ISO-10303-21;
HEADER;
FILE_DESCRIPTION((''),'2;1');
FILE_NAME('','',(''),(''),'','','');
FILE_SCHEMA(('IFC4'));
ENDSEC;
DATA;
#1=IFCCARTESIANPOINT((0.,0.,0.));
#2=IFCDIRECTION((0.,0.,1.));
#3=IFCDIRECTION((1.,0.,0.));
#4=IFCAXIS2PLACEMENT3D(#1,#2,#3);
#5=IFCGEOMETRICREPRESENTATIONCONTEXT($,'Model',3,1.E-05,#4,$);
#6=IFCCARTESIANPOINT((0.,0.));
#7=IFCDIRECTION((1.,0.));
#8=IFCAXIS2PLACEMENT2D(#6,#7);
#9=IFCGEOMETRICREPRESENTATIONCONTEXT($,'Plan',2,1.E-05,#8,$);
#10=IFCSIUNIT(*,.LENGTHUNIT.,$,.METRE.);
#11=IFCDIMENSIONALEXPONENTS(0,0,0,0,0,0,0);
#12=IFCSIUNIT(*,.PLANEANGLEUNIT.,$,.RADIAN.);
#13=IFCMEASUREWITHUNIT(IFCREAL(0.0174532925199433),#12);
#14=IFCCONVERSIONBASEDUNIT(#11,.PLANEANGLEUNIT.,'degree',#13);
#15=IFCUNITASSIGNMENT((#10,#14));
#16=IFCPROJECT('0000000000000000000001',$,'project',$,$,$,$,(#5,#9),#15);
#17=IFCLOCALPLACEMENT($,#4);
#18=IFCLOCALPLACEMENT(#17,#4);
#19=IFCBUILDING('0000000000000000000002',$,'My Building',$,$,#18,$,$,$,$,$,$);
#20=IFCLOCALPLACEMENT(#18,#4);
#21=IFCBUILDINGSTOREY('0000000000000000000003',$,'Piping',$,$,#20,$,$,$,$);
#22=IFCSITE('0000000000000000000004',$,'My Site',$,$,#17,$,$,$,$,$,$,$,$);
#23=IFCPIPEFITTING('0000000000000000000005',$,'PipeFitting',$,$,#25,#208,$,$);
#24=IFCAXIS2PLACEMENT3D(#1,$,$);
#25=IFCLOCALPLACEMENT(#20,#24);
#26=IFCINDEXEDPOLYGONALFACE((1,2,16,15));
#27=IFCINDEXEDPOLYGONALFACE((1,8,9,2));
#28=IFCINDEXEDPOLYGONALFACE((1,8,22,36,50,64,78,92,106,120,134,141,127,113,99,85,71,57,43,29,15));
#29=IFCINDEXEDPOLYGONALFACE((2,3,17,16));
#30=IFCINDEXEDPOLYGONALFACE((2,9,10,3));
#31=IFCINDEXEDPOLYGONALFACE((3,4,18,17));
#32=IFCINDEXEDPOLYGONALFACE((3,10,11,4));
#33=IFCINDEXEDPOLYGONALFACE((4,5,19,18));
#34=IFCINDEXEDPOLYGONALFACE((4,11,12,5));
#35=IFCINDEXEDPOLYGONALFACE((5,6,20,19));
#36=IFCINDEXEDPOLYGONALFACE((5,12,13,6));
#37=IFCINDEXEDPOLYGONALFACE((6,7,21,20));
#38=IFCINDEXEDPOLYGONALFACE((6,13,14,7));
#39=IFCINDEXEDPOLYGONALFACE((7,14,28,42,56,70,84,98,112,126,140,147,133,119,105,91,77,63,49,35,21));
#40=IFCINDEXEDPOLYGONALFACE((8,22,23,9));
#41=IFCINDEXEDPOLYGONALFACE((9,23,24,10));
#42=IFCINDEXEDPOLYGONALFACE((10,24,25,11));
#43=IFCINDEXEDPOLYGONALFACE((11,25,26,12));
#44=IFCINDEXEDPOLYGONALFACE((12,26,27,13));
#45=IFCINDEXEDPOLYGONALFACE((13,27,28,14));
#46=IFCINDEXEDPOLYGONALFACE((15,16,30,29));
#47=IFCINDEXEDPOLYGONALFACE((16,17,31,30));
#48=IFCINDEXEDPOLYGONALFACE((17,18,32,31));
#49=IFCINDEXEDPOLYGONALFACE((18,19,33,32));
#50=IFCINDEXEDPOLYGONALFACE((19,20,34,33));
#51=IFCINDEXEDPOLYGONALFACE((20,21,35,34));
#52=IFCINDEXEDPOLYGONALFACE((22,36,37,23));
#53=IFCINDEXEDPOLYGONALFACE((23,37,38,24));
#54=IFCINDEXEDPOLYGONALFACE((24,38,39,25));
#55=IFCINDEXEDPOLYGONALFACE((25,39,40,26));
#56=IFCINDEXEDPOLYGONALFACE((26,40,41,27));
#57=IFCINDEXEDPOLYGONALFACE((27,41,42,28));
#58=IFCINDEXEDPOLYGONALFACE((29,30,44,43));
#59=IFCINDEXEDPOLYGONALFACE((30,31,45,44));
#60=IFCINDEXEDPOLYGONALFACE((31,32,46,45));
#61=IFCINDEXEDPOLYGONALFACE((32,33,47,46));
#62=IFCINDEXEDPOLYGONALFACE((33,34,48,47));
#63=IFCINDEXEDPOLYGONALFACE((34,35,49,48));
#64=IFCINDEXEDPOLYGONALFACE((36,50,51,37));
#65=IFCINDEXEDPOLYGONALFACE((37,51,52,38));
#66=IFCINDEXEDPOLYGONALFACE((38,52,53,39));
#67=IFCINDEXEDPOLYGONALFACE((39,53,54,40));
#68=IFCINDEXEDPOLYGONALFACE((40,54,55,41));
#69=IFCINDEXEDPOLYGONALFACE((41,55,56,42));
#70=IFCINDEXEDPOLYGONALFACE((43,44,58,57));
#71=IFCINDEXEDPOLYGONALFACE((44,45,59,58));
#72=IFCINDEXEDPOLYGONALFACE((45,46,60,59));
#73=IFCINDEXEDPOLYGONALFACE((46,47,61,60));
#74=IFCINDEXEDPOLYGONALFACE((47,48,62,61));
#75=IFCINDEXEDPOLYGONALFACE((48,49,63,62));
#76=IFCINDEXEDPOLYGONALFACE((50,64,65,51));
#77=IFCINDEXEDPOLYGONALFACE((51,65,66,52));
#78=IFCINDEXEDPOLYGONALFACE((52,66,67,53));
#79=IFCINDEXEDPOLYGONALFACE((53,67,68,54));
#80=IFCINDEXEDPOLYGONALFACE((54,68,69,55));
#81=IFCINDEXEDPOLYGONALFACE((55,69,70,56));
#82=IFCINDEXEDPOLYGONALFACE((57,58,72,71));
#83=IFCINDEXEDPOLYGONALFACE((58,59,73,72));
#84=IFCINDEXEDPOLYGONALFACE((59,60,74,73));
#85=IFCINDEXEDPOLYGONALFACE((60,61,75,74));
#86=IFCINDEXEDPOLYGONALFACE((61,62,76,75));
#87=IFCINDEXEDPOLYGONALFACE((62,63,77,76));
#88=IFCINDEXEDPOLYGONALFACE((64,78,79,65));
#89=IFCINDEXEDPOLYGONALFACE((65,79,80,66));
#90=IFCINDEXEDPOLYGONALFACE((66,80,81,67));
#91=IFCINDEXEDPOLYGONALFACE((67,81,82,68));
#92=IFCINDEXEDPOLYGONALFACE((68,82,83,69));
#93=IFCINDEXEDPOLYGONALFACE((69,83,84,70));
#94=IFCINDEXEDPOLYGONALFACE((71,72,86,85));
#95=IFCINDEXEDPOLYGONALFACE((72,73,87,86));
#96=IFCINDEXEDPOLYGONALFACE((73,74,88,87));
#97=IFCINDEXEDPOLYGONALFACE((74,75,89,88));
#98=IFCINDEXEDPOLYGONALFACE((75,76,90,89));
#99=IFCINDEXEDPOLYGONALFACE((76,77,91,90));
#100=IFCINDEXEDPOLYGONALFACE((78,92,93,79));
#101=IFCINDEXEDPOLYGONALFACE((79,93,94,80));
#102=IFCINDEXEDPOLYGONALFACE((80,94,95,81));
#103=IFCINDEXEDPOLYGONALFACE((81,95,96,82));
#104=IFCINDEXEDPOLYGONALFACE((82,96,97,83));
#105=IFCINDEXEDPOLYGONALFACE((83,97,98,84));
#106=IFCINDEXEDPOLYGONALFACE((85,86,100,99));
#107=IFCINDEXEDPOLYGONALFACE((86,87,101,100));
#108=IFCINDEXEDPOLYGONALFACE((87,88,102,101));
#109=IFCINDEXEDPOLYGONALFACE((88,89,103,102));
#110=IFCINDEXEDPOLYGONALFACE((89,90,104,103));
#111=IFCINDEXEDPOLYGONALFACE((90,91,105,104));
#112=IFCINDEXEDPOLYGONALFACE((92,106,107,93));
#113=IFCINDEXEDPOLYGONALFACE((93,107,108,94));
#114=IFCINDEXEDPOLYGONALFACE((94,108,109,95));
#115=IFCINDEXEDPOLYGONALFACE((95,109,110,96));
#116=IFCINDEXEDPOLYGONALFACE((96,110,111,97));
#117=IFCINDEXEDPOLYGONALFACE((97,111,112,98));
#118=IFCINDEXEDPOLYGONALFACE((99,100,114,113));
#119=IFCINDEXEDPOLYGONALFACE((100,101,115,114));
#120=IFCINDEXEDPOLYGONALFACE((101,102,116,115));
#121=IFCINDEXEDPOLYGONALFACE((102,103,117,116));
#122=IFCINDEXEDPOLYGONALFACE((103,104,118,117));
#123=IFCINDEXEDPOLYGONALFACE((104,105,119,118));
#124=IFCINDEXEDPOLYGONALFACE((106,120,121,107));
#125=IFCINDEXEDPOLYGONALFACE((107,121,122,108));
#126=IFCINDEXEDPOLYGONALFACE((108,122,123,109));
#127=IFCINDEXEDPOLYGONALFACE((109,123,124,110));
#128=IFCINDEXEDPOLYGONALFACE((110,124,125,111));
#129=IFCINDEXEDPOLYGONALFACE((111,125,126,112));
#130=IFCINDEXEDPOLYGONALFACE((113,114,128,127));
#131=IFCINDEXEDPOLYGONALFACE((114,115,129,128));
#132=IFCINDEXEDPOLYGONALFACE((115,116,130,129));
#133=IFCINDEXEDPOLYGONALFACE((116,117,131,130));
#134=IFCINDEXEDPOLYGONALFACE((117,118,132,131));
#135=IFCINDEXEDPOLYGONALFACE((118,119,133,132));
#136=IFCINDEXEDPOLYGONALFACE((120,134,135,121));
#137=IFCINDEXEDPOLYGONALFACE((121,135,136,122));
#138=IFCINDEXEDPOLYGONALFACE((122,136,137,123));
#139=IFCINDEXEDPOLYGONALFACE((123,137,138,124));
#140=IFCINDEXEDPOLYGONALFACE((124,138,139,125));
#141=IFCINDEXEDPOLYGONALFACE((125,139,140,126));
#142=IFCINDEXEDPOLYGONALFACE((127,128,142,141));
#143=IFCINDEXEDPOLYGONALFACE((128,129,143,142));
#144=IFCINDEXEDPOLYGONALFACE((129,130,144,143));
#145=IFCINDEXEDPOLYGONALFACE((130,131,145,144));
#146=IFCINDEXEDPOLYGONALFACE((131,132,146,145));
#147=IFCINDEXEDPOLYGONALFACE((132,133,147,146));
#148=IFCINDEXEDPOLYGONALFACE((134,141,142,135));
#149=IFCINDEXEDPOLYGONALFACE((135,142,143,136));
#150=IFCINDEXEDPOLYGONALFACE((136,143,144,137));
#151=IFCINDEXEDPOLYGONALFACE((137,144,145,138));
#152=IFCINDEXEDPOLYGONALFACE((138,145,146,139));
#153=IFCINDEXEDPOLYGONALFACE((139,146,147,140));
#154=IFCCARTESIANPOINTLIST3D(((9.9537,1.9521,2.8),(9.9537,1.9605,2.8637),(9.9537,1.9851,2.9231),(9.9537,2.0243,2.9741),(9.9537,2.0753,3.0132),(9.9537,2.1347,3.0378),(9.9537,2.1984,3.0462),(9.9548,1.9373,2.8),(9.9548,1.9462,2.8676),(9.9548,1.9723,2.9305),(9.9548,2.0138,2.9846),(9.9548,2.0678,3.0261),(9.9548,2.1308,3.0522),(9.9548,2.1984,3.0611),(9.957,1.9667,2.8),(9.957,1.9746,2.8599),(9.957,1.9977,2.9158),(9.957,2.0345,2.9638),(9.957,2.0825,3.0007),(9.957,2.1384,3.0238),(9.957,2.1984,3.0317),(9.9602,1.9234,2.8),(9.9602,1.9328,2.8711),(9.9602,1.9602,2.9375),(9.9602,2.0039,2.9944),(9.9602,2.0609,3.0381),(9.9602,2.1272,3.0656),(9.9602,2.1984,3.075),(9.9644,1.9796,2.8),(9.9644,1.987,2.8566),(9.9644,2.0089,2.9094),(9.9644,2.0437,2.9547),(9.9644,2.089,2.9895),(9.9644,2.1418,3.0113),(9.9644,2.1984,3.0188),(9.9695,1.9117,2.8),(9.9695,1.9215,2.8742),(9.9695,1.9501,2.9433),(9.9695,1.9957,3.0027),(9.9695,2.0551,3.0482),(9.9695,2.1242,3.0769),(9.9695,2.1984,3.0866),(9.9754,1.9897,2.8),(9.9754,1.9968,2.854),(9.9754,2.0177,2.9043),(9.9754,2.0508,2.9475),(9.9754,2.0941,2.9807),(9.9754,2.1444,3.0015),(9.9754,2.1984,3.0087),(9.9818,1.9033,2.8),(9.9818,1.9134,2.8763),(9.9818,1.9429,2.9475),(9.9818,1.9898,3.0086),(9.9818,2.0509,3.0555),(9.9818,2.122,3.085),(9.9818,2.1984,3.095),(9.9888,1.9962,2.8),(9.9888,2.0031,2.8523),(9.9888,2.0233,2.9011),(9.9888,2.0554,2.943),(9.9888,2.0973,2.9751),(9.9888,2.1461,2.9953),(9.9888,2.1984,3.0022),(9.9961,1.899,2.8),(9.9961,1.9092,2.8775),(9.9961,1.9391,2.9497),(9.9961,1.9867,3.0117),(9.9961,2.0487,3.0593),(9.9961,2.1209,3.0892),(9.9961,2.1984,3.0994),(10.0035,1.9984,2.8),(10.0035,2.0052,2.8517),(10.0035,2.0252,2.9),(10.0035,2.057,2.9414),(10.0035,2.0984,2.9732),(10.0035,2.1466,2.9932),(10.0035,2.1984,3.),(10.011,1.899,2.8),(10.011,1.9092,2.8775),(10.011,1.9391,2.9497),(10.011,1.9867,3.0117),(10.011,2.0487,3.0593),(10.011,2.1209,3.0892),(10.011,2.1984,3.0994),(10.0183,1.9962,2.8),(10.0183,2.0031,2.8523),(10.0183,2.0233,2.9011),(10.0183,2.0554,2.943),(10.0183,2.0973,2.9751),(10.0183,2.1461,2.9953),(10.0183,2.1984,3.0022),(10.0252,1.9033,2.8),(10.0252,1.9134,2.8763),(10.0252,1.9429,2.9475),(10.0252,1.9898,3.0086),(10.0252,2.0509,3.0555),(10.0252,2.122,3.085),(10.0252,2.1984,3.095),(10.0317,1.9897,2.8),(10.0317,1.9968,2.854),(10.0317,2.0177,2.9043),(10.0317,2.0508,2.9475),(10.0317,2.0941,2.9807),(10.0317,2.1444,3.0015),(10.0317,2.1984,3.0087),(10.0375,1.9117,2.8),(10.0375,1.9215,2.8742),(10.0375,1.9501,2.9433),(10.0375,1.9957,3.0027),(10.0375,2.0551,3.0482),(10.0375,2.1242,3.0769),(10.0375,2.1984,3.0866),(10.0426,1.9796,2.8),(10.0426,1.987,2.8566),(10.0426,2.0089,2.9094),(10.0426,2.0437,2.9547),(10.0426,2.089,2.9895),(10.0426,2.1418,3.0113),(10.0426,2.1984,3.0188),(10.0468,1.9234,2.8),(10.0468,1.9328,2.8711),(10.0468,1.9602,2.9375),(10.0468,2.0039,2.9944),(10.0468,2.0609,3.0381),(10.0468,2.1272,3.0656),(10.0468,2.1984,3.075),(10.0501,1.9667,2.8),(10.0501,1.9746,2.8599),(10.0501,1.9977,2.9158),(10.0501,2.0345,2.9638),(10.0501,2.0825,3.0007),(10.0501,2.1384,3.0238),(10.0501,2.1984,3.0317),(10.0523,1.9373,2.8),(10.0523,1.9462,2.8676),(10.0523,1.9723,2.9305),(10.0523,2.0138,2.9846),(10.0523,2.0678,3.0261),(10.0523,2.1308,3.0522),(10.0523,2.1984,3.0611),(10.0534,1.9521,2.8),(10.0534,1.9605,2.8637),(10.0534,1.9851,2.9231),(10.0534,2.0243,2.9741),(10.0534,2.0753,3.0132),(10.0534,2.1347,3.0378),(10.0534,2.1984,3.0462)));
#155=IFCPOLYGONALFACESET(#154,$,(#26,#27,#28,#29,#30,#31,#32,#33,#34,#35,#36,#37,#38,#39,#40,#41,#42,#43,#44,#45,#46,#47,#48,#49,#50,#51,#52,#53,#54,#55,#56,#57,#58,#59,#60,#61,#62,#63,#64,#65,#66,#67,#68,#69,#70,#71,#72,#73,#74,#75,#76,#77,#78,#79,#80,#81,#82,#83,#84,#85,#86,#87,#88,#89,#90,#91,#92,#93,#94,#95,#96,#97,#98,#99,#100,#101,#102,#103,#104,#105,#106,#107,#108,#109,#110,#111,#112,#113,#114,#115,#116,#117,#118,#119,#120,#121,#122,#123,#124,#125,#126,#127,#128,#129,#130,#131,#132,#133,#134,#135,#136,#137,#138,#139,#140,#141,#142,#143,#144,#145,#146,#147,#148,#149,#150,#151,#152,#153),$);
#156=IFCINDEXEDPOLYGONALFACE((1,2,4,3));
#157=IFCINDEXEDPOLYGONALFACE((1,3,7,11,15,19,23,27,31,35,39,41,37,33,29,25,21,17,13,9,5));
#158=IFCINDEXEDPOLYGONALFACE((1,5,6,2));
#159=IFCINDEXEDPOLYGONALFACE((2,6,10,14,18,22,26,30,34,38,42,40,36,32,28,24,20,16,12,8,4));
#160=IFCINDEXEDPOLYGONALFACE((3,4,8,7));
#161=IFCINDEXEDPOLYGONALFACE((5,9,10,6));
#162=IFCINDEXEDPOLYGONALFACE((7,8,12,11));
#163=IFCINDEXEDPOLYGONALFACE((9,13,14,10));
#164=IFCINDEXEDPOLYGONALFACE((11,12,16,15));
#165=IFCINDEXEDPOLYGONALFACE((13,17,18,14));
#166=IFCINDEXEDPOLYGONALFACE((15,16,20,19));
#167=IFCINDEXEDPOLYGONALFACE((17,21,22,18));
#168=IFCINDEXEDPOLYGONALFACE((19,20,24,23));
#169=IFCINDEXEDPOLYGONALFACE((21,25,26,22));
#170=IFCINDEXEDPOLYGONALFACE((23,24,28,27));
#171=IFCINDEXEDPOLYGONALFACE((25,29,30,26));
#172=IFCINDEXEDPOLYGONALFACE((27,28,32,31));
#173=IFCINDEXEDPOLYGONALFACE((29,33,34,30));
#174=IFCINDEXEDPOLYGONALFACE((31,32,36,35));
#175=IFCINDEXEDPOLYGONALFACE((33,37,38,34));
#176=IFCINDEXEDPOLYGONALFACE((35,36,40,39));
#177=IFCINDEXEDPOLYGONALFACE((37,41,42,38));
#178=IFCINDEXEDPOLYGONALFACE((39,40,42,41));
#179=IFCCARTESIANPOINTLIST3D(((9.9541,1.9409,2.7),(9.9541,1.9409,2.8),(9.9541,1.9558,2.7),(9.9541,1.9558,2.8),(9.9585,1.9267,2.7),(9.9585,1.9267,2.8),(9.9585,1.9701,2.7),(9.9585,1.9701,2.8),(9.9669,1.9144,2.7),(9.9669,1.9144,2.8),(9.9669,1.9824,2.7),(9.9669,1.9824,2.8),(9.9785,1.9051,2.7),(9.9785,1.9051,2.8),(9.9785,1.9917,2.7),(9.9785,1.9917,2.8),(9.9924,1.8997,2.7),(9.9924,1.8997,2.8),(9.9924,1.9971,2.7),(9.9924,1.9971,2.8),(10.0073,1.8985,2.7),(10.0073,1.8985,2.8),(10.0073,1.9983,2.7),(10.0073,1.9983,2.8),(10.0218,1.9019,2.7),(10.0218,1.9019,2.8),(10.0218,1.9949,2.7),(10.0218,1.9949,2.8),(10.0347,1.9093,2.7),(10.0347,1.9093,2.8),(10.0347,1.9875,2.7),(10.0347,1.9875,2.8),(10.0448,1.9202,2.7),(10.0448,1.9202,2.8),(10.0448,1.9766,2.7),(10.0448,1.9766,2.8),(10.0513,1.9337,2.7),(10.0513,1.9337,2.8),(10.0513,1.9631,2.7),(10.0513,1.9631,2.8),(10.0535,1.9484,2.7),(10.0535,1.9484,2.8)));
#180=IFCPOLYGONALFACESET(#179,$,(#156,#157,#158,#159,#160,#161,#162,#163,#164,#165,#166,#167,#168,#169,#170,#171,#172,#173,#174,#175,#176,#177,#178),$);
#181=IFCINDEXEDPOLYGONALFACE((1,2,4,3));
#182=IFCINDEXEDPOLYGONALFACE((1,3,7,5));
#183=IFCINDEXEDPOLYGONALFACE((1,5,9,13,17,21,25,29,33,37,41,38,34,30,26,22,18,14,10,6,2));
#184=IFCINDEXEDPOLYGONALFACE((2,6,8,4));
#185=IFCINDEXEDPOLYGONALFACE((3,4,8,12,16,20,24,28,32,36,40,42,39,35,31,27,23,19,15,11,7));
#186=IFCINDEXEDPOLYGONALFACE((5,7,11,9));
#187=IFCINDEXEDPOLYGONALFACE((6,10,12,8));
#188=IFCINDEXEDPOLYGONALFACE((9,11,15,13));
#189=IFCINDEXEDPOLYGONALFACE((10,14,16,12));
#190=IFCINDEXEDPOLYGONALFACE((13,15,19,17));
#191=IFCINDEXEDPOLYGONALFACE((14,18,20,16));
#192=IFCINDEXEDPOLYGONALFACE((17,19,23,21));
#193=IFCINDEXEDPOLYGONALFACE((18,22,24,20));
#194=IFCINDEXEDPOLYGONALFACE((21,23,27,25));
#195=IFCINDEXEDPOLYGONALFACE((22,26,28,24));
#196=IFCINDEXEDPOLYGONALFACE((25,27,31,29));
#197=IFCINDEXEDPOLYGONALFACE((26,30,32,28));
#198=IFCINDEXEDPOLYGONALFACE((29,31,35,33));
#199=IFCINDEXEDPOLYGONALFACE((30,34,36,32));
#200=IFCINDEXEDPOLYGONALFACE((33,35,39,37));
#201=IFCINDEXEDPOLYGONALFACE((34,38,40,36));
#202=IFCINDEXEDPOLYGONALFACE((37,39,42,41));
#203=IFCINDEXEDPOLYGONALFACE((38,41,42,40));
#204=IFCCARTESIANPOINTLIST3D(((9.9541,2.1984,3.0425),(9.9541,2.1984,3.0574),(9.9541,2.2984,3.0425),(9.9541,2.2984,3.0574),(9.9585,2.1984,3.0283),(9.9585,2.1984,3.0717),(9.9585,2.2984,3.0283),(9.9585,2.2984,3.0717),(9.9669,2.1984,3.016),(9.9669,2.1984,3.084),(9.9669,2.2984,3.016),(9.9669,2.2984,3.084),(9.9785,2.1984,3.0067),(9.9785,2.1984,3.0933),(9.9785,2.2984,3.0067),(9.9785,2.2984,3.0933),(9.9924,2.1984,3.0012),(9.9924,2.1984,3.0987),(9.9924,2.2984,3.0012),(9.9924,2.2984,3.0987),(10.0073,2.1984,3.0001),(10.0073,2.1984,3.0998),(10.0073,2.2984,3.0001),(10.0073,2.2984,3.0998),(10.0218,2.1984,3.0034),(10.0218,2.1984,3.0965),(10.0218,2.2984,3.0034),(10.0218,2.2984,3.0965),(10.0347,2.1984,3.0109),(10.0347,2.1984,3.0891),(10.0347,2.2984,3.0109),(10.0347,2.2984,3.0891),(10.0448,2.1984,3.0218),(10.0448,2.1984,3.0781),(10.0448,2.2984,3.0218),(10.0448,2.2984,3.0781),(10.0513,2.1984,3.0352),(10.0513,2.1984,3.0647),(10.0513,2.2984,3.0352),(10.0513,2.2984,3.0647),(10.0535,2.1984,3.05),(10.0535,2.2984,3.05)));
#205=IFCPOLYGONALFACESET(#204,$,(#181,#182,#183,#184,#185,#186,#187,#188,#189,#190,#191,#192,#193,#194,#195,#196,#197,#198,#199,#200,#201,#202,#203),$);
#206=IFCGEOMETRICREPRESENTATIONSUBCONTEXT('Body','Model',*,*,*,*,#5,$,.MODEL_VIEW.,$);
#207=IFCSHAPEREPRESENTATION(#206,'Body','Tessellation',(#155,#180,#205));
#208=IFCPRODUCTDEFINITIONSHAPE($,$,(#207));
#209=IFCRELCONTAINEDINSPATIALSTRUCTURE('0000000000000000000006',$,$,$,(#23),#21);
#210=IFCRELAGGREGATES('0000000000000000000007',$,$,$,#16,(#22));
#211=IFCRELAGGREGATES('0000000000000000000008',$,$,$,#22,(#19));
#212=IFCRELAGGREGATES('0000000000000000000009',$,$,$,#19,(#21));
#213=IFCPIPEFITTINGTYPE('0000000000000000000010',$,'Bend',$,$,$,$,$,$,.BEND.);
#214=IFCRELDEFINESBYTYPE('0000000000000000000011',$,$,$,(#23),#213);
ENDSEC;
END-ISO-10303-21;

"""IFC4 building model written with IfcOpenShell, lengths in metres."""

from ifc_helpers import new_model, entity, si_unit, converted_unit, frame, origin_with_axes, origin_2d_with_axis, place, context, subcontext, project, spatial, circle, extrude, source, transform, mapped, type_object, type_shapes, element, save


model = new_model("IFC4")

# Units and contexts
model_context = context("Model", 3, precision=1e-05, world=origin_with_axes())
plan_context = context("Plan", 2, precision=1e-05, world=origin_2d_with_axis())
body_context = subcontext(model_context, "Body", "Model", "MODEL_VIEW")
ifc_project = project(units=[si_unit("LENGTHUNIT", "METRE"), converted_unit("PLANEANGLEUNIT", "degree", entity("IfcReal", 0.0174532925199433), si_unit("PLANEANGLEUNIT", "RADIAN"), dimensions=[0, 0, 0, 0, 0, 0, 0])], contexts=[model_context, plan_context])

# Site, building, storey
site_placement = place(None, origin_with_axes())
site = spatial("IfcSite", under=ifc_project, at=site_placement, Name="My Site")
building_placement = place(site_placement, origin_with_axes())
building = spatial("IfcBuilding", under=site, at=building_placement, Name="My Building")
storey_placement = place(building_placement, origin_with_axes())
storey = spatial("IfcBuildingStorey", under=building, at=storey_placement, Name="Piping")

# Pipe fitting
pipe_fitting_type_1 = type_object("IfcPipeFittingType", Name="Bend", PredefinedType="BEND")
shared_shape = source(origin_with_axes(), body_context, "Body", "SolidModel", [
    entity("IfcSweptDiskSolid", entity("IfcIndexedPolyCurve", entity("IfcCartesianPointList3D", [[0.0, 0.0, -0.1], [0.0, -0.0732, -0.2768], [0.0, -0.25, -0.35]]), [entity("IfcArcIndex", [1, 2, 3])]), 0.05),
    extrude(circle(Radius=0.05), origin_with_axes(), (0.0, 0.0, -1.0), 0.1),
    extrude(circle(Radius=0.05), frame((0.0, -0.25, -0.35), z_axis=(0.0, -1.0, 0.0), x_axis=(1.0, 0.0, 0.0)), (0.0, 0.0, 1.0), 0.1),
])
type_shapes(pipe_fitting_type_1, [shared_shape])
for number, where, z_axis, x_axis, name in (
    (1, (10.0035, 1.9484, 2.7), (0.0, 0.0, -1.0), (1.0, 0.0, 0.0), "PipeFitting"),
):
    element("IfcPipeFitting", number, at=place(storey_placement, frame(where, z_axis=z_axis, x_axis=x_axis)), inside=storey, type_object=pipe_fitting_type_1, Name=name, context=body_context, shape_type="MappedRepresentation", body=[
        mapped(shared_shape, transform((0.0, 0.0, 0.0), x_axis=(1.0, 0.0, 0.0), y_axis=(0.0, 1.0, 0.0), z_axis=(0.0, 0.0, 1.0), scale=1.0)),
    ])

save(model, "model.ifc")
